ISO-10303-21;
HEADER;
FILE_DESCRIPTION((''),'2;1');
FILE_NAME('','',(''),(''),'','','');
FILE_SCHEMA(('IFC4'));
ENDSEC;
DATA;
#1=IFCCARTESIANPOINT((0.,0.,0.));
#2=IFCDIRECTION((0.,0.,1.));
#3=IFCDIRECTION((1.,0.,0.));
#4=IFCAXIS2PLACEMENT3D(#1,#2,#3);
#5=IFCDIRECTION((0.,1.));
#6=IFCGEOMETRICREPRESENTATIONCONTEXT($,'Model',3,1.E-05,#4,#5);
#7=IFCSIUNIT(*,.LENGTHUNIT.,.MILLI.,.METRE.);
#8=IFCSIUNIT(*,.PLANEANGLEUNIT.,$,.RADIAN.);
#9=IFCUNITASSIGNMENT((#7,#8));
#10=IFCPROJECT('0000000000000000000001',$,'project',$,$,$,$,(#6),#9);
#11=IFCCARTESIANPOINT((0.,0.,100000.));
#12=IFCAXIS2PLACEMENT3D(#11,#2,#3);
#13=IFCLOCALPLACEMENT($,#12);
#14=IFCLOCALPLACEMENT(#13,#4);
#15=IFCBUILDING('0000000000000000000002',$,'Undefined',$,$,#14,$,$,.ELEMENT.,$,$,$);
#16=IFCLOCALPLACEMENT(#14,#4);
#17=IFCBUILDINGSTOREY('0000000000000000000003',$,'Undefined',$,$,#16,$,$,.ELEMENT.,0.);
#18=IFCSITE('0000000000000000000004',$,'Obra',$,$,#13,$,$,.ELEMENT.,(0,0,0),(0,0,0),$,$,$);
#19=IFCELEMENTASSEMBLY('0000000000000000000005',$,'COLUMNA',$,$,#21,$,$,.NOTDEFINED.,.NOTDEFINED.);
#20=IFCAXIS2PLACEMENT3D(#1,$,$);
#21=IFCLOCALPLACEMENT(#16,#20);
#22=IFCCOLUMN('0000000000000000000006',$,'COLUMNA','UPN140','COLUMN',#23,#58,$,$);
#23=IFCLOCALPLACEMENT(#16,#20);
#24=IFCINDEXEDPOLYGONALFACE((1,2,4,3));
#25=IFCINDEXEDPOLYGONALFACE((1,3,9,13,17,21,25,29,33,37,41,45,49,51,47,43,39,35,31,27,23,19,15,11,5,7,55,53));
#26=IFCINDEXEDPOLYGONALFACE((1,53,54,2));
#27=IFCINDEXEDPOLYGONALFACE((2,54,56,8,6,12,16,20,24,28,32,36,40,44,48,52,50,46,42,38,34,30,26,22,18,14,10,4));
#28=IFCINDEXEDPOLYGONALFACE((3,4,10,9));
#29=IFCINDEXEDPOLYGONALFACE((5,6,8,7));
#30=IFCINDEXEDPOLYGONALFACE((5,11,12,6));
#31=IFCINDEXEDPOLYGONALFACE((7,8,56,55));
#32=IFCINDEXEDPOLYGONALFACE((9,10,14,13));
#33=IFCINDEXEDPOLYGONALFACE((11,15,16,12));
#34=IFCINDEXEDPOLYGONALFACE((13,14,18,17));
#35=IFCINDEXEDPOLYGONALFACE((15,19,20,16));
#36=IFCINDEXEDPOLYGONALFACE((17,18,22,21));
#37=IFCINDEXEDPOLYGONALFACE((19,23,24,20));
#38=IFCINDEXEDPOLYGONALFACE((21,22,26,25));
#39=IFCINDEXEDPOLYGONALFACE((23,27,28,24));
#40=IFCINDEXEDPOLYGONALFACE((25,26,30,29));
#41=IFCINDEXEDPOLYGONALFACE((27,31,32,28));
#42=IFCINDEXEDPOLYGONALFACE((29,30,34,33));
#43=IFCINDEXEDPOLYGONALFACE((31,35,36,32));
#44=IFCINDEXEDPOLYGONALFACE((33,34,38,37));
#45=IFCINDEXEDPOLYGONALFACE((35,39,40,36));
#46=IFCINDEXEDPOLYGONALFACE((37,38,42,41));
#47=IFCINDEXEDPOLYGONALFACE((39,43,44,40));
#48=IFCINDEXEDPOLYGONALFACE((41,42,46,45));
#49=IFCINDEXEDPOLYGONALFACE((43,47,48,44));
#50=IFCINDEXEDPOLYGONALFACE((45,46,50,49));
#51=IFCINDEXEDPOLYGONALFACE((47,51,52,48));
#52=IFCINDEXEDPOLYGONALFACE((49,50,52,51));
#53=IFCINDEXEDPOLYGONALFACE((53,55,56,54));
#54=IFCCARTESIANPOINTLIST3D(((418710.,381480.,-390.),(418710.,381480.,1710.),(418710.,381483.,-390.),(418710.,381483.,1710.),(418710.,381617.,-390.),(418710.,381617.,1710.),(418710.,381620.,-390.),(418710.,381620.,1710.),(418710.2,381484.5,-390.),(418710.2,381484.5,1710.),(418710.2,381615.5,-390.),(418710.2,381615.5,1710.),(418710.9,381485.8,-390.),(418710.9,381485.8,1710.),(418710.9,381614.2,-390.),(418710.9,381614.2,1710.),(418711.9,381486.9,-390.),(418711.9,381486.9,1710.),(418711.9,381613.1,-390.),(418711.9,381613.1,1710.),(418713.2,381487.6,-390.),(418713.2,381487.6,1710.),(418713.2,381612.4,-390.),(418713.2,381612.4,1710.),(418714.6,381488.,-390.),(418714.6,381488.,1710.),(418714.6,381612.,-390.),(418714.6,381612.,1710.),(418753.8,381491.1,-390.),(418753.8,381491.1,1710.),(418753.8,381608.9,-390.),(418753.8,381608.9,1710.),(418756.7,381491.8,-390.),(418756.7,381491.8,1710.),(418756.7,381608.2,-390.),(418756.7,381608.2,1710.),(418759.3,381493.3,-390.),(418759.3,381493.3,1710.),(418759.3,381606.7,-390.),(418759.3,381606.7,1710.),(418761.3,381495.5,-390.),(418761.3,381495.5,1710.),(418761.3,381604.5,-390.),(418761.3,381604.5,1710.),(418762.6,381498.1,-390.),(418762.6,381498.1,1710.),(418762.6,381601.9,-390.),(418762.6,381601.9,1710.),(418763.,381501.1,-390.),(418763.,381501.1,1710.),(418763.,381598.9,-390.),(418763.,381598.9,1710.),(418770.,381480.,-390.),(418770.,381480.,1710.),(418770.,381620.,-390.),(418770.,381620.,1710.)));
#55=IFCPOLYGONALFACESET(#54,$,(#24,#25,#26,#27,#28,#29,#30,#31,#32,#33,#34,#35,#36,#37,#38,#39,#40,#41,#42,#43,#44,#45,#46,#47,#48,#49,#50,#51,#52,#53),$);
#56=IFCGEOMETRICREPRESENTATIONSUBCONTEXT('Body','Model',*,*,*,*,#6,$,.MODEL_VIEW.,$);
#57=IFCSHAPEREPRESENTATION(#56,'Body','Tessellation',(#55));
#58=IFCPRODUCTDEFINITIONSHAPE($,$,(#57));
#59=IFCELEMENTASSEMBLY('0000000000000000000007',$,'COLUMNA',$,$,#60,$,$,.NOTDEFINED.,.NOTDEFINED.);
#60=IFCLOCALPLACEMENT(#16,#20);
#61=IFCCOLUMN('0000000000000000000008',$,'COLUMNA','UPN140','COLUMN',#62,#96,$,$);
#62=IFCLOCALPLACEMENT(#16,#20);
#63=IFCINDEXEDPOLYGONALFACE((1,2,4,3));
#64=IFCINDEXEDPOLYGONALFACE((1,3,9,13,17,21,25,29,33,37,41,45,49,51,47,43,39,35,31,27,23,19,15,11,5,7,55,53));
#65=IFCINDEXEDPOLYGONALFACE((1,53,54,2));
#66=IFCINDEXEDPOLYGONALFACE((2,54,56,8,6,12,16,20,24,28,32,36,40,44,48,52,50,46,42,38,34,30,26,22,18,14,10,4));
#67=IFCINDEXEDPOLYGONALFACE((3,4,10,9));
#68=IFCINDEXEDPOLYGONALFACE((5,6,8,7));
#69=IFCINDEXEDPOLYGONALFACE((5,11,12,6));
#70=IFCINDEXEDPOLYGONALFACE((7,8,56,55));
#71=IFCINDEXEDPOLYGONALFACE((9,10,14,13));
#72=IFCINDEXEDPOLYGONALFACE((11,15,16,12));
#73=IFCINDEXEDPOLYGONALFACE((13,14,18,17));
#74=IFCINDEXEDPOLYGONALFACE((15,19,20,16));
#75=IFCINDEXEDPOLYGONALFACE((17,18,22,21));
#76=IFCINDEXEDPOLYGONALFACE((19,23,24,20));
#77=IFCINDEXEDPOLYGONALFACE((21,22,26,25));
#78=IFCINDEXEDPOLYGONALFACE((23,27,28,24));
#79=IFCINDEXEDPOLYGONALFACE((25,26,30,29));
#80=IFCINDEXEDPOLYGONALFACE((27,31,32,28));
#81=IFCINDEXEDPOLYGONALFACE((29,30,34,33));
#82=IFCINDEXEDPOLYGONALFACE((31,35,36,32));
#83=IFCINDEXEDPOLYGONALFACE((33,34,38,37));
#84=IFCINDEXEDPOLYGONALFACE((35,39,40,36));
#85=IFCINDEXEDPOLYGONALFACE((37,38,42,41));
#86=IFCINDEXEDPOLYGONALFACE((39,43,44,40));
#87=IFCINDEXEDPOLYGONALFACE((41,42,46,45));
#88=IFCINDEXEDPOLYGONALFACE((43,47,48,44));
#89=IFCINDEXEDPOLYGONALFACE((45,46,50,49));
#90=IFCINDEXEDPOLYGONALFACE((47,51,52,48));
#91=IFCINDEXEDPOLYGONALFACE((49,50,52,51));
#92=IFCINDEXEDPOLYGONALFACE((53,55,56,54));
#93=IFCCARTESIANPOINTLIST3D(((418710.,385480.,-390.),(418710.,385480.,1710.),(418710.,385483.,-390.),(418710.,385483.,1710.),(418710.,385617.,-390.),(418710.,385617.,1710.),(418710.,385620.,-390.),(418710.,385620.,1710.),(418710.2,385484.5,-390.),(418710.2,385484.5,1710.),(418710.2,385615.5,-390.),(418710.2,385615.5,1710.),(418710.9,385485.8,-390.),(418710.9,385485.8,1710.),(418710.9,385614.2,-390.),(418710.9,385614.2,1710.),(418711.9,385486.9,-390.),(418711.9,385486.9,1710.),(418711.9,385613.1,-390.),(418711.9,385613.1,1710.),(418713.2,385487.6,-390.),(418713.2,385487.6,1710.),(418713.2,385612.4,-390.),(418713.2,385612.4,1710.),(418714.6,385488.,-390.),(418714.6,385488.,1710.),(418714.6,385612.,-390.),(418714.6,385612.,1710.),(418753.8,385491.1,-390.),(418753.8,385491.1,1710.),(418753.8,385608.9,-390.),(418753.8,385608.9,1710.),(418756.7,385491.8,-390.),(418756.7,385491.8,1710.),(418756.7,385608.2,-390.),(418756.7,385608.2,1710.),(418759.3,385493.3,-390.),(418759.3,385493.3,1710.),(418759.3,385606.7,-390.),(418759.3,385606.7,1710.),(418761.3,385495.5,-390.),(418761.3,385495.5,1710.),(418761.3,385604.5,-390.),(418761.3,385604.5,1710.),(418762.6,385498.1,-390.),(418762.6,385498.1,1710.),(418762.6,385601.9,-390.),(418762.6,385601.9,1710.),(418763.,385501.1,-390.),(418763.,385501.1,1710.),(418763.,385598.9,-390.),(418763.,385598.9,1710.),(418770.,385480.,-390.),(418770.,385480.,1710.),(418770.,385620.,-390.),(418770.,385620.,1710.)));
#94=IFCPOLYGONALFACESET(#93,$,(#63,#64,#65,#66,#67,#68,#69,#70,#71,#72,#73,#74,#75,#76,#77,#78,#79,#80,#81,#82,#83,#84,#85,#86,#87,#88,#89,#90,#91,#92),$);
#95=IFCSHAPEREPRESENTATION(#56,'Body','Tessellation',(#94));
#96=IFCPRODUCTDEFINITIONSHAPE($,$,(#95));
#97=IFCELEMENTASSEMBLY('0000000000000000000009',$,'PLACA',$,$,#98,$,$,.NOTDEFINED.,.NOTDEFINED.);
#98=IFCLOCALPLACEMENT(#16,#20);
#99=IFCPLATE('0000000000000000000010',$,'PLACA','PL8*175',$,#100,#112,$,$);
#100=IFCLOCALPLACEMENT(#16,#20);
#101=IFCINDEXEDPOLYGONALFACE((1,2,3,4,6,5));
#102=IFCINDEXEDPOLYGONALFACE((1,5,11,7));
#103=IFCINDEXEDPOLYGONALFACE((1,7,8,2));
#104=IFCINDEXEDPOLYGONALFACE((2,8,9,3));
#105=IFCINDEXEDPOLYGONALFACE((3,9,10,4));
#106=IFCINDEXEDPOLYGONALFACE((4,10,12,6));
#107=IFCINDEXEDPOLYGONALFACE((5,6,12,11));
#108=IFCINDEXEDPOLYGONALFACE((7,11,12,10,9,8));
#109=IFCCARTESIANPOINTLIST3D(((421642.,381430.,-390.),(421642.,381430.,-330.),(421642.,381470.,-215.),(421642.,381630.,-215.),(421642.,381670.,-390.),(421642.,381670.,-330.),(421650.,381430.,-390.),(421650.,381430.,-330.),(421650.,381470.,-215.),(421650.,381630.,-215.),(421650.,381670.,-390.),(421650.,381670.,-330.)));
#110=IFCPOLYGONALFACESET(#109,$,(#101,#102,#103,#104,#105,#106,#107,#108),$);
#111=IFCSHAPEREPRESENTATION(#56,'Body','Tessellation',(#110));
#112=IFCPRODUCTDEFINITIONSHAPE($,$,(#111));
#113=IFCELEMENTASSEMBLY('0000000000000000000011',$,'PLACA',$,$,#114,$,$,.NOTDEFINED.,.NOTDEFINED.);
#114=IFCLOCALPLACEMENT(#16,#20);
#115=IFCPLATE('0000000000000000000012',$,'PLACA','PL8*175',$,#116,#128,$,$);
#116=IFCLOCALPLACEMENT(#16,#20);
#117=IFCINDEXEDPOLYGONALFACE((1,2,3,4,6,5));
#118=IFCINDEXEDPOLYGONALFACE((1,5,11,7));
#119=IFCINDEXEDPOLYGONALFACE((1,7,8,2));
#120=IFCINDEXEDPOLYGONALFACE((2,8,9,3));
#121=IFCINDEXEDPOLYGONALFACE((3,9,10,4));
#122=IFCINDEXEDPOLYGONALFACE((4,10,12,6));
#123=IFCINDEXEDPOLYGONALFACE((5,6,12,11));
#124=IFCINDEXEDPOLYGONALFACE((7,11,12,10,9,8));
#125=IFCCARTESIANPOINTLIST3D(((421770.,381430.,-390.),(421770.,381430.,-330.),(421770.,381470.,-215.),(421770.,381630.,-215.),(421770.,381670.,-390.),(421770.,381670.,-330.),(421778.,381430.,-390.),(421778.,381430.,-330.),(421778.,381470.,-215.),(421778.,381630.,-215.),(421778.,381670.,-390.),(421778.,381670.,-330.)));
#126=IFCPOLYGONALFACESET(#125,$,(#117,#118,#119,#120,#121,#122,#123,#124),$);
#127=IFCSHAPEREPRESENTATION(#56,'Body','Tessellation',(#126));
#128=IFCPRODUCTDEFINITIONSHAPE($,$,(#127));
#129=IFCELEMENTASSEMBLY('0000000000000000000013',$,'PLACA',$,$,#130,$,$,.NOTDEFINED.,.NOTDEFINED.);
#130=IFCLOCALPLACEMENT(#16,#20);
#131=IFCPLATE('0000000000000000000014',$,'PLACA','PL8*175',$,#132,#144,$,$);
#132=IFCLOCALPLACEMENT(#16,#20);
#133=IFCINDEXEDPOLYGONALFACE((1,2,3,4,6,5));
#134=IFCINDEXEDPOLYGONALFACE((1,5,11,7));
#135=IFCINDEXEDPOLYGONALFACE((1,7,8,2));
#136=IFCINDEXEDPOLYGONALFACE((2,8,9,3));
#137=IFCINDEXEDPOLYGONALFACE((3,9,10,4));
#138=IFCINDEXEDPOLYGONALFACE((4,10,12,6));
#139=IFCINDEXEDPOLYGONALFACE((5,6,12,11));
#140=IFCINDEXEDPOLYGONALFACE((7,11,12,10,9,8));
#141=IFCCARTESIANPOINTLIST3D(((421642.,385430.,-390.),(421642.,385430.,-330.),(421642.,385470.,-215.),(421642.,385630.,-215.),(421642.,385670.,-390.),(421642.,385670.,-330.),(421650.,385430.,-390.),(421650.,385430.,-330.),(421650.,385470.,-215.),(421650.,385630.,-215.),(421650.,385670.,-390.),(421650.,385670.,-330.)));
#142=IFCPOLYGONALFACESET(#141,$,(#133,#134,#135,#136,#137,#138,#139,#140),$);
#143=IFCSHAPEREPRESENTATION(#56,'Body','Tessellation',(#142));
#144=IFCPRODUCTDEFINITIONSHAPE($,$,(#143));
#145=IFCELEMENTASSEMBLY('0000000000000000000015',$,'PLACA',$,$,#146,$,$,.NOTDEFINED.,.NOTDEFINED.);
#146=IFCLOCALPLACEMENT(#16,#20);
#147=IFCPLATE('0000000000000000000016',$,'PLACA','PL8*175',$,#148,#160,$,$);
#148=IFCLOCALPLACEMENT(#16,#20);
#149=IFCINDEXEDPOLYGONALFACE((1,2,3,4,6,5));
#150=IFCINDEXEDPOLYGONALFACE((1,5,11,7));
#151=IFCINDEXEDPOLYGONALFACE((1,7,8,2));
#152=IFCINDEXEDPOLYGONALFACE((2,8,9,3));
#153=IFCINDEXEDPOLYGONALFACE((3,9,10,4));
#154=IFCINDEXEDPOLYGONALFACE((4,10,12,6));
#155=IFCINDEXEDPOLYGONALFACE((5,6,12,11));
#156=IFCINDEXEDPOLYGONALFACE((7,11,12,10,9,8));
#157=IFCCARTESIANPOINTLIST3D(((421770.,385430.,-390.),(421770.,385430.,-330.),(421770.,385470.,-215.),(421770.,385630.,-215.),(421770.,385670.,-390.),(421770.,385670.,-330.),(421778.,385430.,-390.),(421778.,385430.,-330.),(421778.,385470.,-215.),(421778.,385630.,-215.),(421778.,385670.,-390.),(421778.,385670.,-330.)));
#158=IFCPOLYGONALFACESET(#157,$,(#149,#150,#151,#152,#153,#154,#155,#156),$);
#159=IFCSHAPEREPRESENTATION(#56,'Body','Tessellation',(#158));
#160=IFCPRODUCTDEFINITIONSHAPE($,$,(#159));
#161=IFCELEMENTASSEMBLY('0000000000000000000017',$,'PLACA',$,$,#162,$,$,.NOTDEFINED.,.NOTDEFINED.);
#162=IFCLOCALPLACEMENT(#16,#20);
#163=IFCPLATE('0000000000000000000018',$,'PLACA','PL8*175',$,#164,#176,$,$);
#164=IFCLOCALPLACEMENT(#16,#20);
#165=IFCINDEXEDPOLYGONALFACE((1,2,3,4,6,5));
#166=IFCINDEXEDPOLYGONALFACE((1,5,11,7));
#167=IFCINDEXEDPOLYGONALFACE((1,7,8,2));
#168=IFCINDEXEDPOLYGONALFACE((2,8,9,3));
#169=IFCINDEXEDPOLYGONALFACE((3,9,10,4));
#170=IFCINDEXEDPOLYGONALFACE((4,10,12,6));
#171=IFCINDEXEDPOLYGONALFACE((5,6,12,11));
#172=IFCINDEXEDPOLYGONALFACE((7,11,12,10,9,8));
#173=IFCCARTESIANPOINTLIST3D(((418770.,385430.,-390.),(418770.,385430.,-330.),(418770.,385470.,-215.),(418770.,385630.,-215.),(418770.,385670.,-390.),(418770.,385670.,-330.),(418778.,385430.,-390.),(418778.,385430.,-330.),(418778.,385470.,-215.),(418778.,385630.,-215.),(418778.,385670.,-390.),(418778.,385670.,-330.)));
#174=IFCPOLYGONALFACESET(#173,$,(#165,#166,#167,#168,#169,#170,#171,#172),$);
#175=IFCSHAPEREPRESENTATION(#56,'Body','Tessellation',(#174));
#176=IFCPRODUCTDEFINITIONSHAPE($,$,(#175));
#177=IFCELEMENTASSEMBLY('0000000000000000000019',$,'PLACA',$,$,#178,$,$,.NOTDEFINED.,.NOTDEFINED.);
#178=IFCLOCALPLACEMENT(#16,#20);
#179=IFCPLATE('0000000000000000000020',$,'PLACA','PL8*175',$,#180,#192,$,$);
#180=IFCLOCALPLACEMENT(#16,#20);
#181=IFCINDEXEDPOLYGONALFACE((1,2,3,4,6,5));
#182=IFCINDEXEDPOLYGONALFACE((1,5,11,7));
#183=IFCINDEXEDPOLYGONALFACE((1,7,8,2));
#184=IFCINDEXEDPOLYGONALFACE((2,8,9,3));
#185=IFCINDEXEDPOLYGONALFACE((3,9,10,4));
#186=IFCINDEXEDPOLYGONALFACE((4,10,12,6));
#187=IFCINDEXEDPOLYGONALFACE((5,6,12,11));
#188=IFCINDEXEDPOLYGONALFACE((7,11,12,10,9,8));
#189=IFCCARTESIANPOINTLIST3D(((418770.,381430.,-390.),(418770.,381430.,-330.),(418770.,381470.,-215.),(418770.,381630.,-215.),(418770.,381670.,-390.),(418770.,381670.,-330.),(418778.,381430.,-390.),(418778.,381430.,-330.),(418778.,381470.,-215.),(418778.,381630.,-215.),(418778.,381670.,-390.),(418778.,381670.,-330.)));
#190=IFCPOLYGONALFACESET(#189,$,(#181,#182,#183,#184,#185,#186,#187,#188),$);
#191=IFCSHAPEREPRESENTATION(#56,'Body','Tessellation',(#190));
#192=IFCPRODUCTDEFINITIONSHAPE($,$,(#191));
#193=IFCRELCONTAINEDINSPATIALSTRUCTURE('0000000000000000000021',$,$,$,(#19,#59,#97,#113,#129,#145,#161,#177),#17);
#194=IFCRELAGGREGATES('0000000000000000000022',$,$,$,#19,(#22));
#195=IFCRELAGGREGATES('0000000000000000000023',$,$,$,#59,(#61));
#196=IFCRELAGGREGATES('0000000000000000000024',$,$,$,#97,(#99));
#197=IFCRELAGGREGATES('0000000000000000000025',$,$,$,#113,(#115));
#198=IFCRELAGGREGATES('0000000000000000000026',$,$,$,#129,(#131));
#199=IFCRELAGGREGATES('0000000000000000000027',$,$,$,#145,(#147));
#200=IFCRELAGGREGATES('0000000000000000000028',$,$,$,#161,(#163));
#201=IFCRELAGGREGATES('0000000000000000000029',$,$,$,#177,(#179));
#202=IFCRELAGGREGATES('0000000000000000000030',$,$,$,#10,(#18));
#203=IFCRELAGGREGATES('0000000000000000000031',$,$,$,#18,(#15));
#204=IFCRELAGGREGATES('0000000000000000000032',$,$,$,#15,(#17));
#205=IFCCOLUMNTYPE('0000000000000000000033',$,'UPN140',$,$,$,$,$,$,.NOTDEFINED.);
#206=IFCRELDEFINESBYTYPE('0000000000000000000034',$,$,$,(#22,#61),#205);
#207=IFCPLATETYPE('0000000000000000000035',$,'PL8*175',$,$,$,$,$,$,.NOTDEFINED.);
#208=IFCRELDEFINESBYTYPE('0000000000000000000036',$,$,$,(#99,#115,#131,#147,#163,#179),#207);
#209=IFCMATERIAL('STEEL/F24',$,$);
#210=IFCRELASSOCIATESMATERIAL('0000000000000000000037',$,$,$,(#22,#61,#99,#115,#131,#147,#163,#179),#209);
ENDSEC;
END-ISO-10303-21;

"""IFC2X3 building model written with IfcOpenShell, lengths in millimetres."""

from ifc_helpers import new_model, si_unit, direction, frame, origin_with_axes, origin_2d_with_axis, place, context, subcontext, project, spatial, polyline, u_section, outline, extrude, material, type_object, element, aggregate, save


model = new_model("IFC2X3")

# Units and contexts
model_context = context("Model", 3, precision=1e-05, world=origin_with_axes(), true_north=direction((0.0, 1.0)))
body_context = subcontext(model_context, "Body", "Model", "MODEL_VIEW")
ifc_project = project(units=[si_unit("LENGTHUNIT", "METRE", prefix="MILLI"), si_unit("PLANEANGLEUNIT", "RADIAN")], contexts=[model_context])

# Site, building, storey
site_placement = place(None, frame((0.0, 0.0, 100000.0), z_axis=(0.0, 0.0, 1.0), x_axis=(1.0, 0.0, 0.0)))
site = spatial("IfcSite", under=ifc_project, at=site_placement, Name="Obra", CompositionType="ELEMENT", RefLatitude=(0, 0, 0), RefLongitude=(0, 0, 0))
building_placement = place(site_placement, origin_with_axes())
building = spatial("IfcBuilding", under=site, at=building_placement, Name="Undefined", CompositionType="ELEMENT")
storey_placement = place(building_placement, origin_with_axes())
storey = spatial("IfcBuildingStorey", under=building, at=storey_placement, Name="Undefined", CompositionType="ELEMENT", Elevation=0.0)

# Element assemblies, columns
ifc_material_1 = material(Name="STEEL/F24")
column_type_1 = type_object("IfcColumnType", Name="UPN140", PredefinedType="NOTDEFINED")
assembly_1_placement = place(storey_placement, origin_with_axes())
assembly_1 = element("IfcElementAssembly", 1, at=assembly_1_placement, inside=storey, Name="COLUMNA", AssemblyPlace="NOTDEFINED", PredefinedType="NOTDEFINED")
column_1_placement = place(assembly_1_placement, frame((418740.0, 381550.0, -390.0), z_axis=(0.0, 0.0, 1.0), x_axis=(0.0, 1.0, 0.0)))
column_1 = element("IfcColumn", 2, at=column_1_placement, type_object=column_type_1, material=ifc_material_1, Name="COLUMNA", Description="UPN140", ObjectType="COLUMN", context=body_context, shape_type="SweptSolid", body=[
    extrude(u_section(Depth=140.0, FlangeWidth=60.0, WebThickness=7.0, FlangeThickness=10.0, FilletRadius=10.0, EdgeRadius=5.0, FlangeSlope=0.07983, at=origin_2d_with_axis()), frame((0.0, 0.0, 2100.0), z_axis=(0.0, 0.0, -1.0), x_axis=(0.0, 1.0, 0.0)), (0.0, 0.0, 1.0), 2100.0),
])
aggregate(assembly_1, [column_1])
assembly_2_placement = place(storey_placement, origin_with_axes())
assembly_2 = element("IfcElementAssembly", 3, at=assembly_2_placement, inside=storey, Name="COLUMNA", AssemblyPlace="NOTDEFINED", PredefinedType="NOTDEFINED")
column_2_placement = place(assembly_2_placement, frame((418740.0, 385550.0, -390.0), z_axis=(0.0, 0.0, 1.0), x_axis=(0.0, 1.0, 0.0)))
column_2 = element("IfcColumn", 4, at=column_2_placement, type_object=column_type_1, material=ifc_material_1, Name="COLUMNA", Description="UPN140", ObjectType="COLUMN", context=body_context, shape_type="SweptSolid", body=[
    extrude(u_section(Depth=140.0, FlangeWidth=60.0, WebThickness=7.0, FlangeThickness=10.0, FilletRadius=10.0, EdgeRadius=5.0, FlangeSlope=0.07983, at=origin_2d_with_axis()), frame((0.0, 0.0, 2100.0), z_axis=(0.0, 0.0, -1.0), x_axis=(0.0, 1.0, 0.0)), (0.0, 0.0, 1.0), 2100.0),
])
aggregate(assembly_2, [column_2])

# Element assemblies, plates
assembly_3_placement = place(storey_placement, origin_with_axes())
assembly_3 = element("IfcElementAssembly", 5, at=assembly_3_placement, inside=storey, Name="PLACA", AssemblyPlace="NOTDEFINED", PredefinedType="NOTDEFINED")
plate_type_1 = type_object("IfcPlateType", Name="PL8*175", PredefinedType="NOTDEFINED")
plate_1_placement = place(assembly_3_placement, frame((421646.0, 381630.0, -215.0), z_axis=(-1.0, 0.0, 0.0), x_axis=(0.0, 0.328521, -0.944497)))
plate_1 = element("IfcPlate", 6, at=plate_1_placement, type_object=plate_type_1, material=ifc_material_1, Name="PLACA", Description="PL8*175", context=body_context, shape_type="SweptSolid", body=[
    extrude(outline(polyline([(0.0, 0.0), (121.8, 0.0), (178.4, 19.7), (99.6, 246.4), (42.9, 226.7), (-52.6, 151.1), (0.0, 0.0)])), frame((0.0, 0.0, -4.0), z_axis=(0.0, 0.0, 1.0), x_axis=(1.0, 0.0, 0.0)), (0.0, 0.0, 1.0), 8.0),
])
aggregate(assembly_3, [plate_1])
assembly_4_placement = place(storey_placement, origin_with_axes())
assembly_4 = element("IfcElementAssembly", 7, at=assembly_4_placement, inside=storey, Name="PLACA", AssemblyPlace="NOTDEFINED", PredefinedType="NOTDEFINED")
plate_2_placement = place(assembly_4_placement, frame((421774.0, 381630.0, -215.0), z_axis=(-1.0, 0.0, 0.0), x_axis=(0.0, 0.328521, -0.944497)))
plate_2 = element("IfcPlate", 8, at=plate_2_placement, type_object=plate_type_1, material=ifc_material_1, Name="PLACA", Description="PL8*175", context=body_context, shape_type="SweptSolid", body=[
    extrude(outline(polyline([(0.0, 0.0), (121.8, 0.0), (178.4, 19.7), (99.6, 246.4), (42.9, 226.7), (-52.6, 151.1), (0.0, 0.0)])), frame((0.0, 0.0, -4.0), z_axis=(0.0, 0.0, 1.0), x_axis=(1.0, 0.0, 0.0)), (0.0, 0.0, 1.0), 8.0),
])
aggregate(assembly_4, [plate_2])
assembly_5_placement = place(storey_placement, origin_with_axes())
assembly_5 = element("IfcElementAssembly", 9, at=assembly_5_placement, inside=storey, Name="PLACA", AssemblyPlace="NOTDEFINED", PredefinedType="NOTDEFINED")
plate_3_placement = place(assembly_5_placement, frame((421646.0, 385630.0, -215.0), z_axis=(-1.0, 0.0, 0.0), x_axis=(0.0, 0.328521, -0.944497)))
plate_3 = element("IfcPlate", 10, at=plate_3_placement, type_object=plate_type_1, material=ifc_material_1, Name="PLACA", Description="PL8*175", context=body_context, shape_type="SweptSolid", body=[
    extrude(outline(polyline([(0.0, 0.0), (121.8, 0.0), (178.4, 19.7), (99.6, 246.4), (42.9, 226.7), (-52.6, 151.1), (0.0, 0.0)])), frame((0.0, 0.0, -4.0), z_axis=(0.0, 0.0, 1.0), x_axis=(1.0, 0.0, 0.0)), (0.0, 0.0, 1.0), 8.0),
])
aggregate(assembly_5, [plate_3])
assembly_6_placement = place(storey_placement, origin_with_axes())
assembly_6 = element("IfcElementAssembly", 11, at=assembly_6_placement, inside=storey, Name="PLACA", AssemblyPlace="NOTDEFINED", PredefinedType="NOTDEFINED")
plate_4_placement = place(assembly_6_placement, frame((421774.0, 385630.0, -215.0), z_axis=(-1.0, 0.0, 0.0), x_axis=(0.0, 0.328521, -0.944497)))
plate_4 = element("IfcPlate", 12, at=plate_4_placement, type_object=plate_type_1, material=ifc_material_1, Name="PLACA", Description="PL8*175", context=body_context, shape_type="SweptSolid", body=[
    extrude(outline(polyline([(0.0, 0.0), (121.8, 0.0), (178.4, 19.7), (99.6, 246.4), (42.9, 226.7), (-52.6, 151.1), (0.0, 0.0)])), frame((0.0, 0.0, -4.0), z_axis=(0.0, 0.0, 1.0), x_axis=(1.0, 0.0, 0.0)), (0.0, 0.0, 1.0), 8.0),
])
aggregate(assembly_6, [plate_4])
assembly_7_placement = place(storey_placement, origin_with_axes())
assembly_7 = element("IfcElementAssembly", 13, at=assembly_7_placement, inside=storey, Name="PLACA", AssemblyPlace="NOTDEFINED", PredefinedType="NOTDEFINED")
plate_5_placement = place(assembly_7_placement, frame((418774.0, 385630.0, -215.0), z_axis=(-1.0, 0.0, 0.0), x_axis=(0.0, 0.328521, -0.944497)))
plate_5 = element("IfcPlate", 14, at=plate_5_placement, type_object=plate_type_1, material=ifc_material_1, Name="PLACA", Description="PL8*175", context=body_context, shape_type="SweptSolid", body=[
    extrude(outline(polyline([(0.0, 0.0), (121.8, 0.0), (178.4, 19.7), (99.6, 246.4), (42.9, 226.7), (-52.6, 151.1), (0.0, 0.0)])), frame((0.0, 0.0, -4.0), z_axis=(0.0, 0.0, 1.0), x_axis=(1.0, 0.0, 0.0)), (0.0, 0.0, 1.0), 8.0),
])
aggregate(assembly_7, [plate_5])
assembly_8_placement = place(storey_placement, origin_with_axes())
assembly_8 = element("IfcElementAssembly", 15, at=assembly_8_placement, inside=storey, Name="PLACA", AssemblyPlace="NOTDEFINED", PredefinedType="NOTDEFINED")
plate_6_placement = place(assembly_8_placement, frame((418774.0, 381630.0, -215.0), z_axis=(-1.0, 0.0, 0.0), x_axis=(0.0, 0.328521, -0.944497)))
plate_6 = element("IfcPlate", 16, at=plate_6_placement, type_object=plate_type_1, material=ifc_material_1, Name="PLACA", Description="PL8*175", context=body_context, shape_type="SweptSolid", body=[
    extrude(outline(polyline([(0.0, 0.0), (121.8, 0.0), (178.4, 19.7), (99.6, 246.4), (42.9, 226.7), (-52.6, 151.1), (0.0, 0.0)])), frame((0.0, 0.0, -4.0), z_axis=(0.0, 0.0, 1.0), x_axis=(1.0, 0.0, 0.0)), (0.0, 0.0, 1.0), 8.0),
])
aggregate(assembly_8, [plate_6])

save(model, "model.ifc")
